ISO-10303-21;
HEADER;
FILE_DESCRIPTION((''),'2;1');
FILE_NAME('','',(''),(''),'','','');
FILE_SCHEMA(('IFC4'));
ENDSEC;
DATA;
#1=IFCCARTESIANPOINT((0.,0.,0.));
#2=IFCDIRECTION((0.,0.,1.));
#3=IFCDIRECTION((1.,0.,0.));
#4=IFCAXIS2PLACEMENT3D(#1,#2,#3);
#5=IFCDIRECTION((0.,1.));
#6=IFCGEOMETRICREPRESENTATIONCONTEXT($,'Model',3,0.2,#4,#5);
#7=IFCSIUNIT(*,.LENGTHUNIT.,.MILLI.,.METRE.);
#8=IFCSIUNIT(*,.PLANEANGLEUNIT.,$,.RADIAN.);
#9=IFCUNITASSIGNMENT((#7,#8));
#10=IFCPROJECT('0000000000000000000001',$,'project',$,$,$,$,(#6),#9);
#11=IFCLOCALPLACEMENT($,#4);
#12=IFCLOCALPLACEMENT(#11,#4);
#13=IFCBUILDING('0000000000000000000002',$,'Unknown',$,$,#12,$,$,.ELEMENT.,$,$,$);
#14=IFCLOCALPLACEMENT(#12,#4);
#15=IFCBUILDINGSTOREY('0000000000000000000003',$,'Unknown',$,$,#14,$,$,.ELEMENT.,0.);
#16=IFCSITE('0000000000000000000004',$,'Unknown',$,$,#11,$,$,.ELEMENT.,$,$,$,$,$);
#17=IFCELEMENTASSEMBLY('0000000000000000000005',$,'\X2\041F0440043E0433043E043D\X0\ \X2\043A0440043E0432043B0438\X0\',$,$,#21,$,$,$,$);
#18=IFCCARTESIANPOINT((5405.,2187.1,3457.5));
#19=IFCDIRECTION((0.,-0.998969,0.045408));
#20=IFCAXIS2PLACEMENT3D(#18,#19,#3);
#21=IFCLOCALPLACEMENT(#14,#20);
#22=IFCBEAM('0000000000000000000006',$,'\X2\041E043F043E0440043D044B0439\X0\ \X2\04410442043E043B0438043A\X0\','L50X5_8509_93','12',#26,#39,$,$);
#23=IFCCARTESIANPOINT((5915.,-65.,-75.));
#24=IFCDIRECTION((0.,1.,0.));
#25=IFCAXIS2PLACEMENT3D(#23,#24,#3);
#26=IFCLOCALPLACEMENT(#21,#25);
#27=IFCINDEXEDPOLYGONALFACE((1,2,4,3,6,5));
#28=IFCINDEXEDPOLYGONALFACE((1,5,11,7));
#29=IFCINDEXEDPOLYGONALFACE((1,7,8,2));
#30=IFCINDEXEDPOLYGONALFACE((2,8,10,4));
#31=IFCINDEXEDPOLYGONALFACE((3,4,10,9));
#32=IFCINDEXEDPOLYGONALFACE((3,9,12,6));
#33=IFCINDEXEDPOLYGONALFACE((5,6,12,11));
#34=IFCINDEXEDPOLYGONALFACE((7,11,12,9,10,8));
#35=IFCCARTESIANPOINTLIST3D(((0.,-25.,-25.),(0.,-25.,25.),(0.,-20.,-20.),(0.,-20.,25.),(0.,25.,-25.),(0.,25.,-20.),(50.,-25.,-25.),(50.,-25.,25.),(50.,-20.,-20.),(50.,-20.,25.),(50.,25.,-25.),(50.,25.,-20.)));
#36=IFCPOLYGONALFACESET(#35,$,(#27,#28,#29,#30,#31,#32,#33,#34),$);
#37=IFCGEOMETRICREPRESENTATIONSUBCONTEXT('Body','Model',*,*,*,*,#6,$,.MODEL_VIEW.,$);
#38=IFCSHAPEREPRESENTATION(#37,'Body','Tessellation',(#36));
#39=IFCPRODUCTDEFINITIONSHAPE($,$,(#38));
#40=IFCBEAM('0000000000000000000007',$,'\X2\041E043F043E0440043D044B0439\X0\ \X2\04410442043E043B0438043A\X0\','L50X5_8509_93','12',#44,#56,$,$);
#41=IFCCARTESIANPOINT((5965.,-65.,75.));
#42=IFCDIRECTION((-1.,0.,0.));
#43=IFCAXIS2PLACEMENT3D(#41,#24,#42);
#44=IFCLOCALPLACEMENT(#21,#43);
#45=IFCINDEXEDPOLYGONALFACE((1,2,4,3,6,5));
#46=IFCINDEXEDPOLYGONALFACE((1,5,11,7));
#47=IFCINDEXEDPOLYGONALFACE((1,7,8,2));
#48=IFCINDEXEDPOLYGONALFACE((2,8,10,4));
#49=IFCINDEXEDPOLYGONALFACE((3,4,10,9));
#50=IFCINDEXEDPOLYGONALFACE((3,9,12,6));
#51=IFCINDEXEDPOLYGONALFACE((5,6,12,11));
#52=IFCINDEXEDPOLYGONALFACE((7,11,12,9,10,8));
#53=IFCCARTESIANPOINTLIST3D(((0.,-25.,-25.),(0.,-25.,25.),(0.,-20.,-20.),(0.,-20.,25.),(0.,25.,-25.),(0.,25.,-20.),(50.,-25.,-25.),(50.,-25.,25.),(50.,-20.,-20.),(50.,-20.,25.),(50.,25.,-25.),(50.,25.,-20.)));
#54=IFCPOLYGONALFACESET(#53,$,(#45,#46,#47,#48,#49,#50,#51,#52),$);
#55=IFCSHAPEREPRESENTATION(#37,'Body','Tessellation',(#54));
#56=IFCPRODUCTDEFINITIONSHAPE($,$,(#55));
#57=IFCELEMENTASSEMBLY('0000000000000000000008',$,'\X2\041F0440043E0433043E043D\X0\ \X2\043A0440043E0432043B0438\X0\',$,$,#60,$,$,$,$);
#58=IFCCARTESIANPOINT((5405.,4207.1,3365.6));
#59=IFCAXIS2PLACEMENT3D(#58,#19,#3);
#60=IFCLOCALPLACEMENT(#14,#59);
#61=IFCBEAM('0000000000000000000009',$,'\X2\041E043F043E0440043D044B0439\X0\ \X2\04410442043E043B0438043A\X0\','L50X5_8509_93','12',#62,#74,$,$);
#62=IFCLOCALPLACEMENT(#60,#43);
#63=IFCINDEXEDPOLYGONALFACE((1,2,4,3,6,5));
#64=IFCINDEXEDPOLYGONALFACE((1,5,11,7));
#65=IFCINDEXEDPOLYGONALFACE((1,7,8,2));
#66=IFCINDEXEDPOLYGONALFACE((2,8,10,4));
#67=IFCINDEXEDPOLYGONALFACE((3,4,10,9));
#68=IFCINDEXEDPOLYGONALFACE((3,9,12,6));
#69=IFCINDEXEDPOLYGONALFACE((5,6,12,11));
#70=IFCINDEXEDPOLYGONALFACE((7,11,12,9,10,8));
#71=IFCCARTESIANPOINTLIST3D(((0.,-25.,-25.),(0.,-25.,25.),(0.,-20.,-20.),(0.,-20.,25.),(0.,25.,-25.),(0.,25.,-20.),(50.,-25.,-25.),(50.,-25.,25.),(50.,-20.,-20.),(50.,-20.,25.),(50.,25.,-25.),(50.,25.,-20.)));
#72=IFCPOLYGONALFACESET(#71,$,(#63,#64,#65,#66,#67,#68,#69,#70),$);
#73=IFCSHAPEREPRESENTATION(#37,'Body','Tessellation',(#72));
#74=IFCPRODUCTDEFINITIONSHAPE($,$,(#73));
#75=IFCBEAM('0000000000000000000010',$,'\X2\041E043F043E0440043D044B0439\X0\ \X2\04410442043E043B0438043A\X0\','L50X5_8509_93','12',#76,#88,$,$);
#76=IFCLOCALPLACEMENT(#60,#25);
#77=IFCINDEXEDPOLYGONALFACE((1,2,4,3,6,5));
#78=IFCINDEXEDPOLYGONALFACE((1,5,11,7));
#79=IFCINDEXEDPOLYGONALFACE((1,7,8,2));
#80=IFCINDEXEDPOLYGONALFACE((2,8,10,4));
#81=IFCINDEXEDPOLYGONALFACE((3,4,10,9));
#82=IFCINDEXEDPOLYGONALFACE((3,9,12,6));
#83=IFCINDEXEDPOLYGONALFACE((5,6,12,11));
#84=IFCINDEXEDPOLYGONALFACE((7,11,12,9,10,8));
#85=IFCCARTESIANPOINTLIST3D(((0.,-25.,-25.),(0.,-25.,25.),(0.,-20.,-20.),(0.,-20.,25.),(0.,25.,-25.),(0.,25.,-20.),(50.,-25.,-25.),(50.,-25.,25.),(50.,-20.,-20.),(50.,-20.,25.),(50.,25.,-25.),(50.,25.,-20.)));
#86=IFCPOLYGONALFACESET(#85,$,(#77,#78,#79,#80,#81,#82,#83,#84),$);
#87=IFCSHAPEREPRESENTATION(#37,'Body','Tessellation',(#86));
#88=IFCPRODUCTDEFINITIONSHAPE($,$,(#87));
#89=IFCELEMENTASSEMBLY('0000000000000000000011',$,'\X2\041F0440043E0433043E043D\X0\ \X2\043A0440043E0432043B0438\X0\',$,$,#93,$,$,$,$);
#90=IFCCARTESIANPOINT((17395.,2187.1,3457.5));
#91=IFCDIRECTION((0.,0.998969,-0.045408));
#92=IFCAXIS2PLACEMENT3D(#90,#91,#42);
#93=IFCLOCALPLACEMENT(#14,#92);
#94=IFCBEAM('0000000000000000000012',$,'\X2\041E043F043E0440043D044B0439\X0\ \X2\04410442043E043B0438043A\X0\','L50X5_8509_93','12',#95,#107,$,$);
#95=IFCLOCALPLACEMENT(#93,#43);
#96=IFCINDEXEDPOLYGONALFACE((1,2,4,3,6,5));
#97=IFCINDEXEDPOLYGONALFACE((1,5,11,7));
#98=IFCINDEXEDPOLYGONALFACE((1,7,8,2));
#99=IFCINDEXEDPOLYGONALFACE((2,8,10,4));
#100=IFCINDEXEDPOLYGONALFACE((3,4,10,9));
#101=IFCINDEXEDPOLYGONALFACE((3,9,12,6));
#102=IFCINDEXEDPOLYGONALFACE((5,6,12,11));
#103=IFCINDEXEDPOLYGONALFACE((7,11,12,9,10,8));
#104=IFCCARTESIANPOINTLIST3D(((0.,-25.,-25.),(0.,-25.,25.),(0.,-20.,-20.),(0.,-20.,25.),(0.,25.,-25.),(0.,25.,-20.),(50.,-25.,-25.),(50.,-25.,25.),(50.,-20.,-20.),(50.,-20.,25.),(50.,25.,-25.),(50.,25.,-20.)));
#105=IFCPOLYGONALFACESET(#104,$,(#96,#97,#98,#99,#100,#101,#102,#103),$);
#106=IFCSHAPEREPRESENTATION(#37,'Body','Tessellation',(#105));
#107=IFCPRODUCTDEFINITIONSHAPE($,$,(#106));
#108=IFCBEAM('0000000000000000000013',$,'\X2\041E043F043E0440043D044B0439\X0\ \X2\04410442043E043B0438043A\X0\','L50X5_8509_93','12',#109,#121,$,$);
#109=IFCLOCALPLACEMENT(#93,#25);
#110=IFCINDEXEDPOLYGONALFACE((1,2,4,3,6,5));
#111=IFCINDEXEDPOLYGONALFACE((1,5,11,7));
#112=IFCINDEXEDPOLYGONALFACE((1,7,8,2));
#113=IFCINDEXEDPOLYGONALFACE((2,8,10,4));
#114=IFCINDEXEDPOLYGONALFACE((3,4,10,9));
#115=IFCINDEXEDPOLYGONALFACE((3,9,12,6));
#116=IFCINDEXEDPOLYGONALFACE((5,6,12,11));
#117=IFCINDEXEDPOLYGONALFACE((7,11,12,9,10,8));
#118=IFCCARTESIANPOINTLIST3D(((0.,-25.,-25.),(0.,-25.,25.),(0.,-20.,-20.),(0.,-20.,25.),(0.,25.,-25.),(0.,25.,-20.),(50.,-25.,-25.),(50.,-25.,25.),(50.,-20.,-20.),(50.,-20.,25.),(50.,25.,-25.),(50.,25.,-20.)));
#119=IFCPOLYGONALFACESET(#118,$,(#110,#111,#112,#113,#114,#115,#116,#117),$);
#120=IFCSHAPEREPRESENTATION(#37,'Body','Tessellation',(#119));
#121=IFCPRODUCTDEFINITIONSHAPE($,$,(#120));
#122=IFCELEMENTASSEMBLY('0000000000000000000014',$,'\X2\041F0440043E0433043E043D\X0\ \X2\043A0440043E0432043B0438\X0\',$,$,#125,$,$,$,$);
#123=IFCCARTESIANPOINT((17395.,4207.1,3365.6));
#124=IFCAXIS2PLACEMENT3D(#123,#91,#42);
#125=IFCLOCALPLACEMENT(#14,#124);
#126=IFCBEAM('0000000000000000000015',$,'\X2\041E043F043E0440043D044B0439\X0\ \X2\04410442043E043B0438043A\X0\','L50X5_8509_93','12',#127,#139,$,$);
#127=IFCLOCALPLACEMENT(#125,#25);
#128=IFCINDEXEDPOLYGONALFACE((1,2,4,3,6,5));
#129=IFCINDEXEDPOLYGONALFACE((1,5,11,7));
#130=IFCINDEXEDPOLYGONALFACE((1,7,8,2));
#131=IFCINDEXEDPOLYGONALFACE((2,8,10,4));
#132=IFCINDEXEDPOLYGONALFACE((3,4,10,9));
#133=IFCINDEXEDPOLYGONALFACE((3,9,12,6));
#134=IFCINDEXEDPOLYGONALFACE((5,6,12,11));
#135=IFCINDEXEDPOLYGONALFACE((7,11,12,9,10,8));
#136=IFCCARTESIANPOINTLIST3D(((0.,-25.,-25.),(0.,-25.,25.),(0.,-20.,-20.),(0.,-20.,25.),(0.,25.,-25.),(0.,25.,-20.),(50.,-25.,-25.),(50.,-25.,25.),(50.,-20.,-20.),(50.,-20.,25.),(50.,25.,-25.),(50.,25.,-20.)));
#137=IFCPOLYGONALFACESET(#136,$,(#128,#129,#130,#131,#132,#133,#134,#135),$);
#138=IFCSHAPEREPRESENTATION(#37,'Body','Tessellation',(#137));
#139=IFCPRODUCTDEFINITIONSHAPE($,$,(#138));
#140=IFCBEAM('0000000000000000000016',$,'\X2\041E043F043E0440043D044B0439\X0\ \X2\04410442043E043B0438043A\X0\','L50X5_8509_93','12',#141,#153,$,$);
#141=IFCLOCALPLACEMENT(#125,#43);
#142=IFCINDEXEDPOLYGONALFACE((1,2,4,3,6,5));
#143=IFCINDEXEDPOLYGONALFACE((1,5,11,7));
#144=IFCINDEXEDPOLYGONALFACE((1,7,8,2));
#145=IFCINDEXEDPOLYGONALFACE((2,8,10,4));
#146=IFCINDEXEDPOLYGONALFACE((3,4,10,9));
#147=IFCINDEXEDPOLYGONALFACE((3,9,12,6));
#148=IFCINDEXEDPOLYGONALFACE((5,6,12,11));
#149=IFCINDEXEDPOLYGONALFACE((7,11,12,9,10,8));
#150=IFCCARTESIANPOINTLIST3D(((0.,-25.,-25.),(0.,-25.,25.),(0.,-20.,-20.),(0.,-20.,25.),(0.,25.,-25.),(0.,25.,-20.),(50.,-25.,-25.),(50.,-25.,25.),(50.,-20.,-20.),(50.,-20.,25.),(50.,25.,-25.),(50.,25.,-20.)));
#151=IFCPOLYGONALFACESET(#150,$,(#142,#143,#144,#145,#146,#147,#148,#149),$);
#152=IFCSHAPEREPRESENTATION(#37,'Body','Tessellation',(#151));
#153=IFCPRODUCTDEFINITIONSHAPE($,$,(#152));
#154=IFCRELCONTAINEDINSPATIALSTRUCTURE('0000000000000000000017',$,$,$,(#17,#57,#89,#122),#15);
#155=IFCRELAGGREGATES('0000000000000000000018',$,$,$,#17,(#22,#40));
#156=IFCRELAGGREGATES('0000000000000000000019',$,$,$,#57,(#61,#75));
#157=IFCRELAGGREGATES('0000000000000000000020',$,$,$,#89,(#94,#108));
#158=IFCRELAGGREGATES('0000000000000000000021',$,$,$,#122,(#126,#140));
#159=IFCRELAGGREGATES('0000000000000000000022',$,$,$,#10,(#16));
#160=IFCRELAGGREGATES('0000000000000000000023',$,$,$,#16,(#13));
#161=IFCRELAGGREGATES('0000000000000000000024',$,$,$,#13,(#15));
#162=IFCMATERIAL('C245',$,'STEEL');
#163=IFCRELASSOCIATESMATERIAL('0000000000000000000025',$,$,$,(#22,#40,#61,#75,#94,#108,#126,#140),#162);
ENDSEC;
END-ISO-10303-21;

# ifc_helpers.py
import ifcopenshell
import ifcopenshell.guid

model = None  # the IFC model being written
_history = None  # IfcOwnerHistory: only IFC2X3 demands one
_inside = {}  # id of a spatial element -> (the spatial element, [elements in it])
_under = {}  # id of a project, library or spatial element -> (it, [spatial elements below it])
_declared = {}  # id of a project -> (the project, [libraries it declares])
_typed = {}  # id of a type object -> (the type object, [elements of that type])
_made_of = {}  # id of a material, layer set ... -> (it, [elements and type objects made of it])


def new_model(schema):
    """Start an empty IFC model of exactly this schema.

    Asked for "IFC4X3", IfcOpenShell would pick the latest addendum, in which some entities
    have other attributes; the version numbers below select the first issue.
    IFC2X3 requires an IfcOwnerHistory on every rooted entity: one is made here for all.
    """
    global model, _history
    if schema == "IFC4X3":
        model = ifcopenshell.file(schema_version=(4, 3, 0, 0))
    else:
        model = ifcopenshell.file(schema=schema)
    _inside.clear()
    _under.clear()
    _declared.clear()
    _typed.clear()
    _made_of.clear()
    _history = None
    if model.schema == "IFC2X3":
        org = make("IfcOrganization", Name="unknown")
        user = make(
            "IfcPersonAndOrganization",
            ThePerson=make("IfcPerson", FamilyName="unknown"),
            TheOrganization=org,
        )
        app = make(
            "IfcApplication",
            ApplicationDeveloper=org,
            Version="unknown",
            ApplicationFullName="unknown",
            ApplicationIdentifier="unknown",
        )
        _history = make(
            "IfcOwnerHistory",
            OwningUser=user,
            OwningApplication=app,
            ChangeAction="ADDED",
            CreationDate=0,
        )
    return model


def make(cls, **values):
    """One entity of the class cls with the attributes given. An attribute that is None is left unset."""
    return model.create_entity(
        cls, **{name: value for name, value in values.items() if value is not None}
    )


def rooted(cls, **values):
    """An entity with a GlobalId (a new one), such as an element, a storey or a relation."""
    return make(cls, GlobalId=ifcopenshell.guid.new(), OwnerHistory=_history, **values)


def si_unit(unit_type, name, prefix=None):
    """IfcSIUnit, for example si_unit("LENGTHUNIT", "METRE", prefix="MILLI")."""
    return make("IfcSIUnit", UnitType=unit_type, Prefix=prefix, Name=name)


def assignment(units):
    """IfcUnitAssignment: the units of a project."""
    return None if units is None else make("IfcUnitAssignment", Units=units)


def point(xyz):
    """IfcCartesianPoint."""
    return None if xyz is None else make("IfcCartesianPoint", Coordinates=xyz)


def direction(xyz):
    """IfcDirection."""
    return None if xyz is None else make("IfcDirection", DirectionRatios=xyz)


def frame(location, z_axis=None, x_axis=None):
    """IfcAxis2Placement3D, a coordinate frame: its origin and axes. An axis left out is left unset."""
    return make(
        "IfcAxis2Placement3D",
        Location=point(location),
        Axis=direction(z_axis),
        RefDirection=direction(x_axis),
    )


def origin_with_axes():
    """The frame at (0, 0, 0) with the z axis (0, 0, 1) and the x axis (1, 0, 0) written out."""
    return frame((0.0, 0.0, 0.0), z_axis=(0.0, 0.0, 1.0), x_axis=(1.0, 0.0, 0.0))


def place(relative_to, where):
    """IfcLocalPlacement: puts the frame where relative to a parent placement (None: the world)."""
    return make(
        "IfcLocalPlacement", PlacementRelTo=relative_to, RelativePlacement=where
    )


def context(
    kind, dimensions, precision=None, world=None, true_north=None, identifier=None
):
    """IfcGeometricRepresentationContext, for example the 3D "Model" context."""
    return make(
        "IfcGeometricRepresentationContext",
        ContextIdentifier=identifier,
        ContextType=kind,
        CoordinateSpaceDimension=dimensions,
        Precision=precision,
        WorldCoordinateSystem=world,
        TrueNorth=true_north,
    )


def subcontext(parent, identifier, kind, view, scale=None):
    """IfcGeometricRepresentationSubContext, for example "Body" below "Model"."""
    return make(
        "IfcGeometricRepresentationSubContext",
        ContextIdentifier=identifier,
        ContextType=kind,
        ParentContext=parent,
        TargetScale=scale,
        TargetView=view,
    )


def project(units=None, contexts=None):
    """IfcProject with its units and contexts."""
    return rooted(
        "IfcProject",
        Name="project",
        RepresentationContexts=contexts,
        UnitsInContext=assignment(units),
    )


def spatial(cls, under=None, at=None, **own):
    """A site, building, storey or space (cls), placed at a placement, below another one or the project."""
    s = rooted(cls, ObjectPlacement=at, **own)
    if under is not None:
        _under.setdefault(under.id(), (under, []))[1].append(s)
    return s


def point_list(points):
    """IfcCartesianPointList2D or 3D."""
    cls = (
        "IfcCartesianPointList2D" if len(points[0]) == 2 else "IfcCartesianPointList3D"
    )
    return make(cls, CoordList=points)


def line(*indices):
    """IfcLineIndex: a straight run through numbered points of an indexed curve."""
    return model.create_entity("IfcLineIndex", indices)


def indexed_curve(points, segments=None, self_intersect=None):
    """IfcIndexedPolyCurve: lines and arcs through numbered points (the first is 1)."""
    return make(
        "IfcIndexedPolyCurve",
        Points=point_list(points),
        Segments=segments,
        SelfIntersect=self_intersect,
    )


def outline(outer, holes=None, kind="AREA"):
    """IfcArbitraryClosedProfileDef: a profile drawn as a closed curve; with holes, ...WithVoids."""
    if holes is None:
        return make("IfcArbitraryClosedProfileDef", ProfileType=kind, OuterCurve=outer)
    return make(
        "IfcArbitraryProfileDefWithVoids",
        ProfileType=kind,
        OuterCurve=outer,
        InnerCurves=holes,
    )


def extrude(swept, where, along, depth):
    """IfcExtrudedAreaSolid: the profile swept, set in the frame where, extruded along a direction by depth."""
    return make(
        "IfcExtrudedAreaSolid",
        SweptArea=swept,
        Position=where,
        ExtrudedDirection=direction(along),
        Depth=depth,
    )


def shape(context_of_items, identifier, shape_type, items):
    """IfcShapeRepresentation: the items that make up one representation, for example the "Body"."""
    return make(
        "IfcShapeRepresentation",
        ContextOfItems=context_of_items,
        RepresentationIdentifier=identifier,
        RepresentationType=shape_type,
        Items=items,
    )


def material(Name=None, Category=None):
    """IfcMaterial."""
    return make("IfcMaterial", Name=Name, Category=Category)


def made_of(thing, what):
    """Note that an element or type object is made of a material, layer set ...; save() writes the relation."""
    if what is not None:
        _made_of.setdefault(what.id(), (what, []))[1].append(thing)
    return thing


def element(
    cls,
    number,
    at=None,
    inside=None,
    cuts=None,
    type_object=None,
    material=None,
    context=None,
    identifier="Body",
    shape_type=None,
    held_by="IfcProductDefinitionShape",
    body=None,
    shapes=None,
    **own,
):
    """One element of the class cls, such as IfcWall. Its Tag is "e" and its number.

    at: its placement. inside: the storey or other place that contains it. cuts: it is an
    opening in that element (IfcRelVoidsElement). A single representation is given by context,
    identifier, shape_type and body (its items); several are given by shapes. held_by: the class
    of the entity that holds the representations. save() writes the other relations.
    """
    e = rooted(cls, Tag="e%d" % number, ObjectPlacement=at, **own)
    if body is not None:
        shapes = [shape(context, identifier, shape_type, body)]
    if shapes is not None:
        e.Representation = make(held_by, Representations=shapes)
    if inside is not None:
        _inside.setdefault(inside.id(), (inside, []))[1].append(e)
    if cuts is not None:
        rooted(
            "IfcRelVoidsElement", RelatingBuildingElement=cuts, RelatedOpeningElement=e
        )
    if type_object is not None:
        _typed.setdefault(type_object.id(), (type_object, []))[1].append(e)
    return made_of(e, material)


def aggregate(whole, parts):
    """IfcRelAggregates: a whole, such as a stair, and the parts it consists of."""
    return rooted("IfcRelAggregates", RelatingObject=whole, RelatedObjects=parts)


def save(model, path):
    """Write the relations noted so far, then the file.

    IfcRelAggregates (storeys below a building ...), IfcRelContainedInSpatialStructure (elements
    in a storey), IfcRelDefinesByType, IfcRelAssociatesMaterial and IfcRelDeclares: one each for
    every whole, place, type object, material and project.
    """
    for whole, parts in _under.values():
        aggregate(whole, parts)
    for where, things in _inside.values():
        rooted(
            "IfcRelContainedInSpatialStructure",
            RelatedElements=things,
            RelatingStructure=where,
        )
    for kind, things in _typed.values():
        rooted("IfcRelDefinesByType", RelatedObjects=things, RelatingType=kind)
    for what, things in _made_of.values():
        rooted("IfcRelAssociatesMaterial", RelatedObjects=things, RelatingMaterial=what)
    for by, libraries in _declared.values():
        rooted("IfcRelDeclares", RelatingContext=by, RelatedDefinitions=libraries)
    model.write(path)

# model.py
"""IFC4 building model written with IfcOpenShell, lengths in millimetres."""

from ifc_helpers import new_model, si_unit, direction, frame, origin_with_axes, place, context, subcontext, project, spatial, line, indexed_curve, outline, extrude, material, element, aggregate, save


model = new_model("IFC4")

# Units and contexts
model_context = context("Model", 3, precision=0.2, world=origin_with_axes(), true_north=direction((0.0, 1.0)))
body_context = subcontext(model_context, "Body", "Model", "MODEL_VIEW")
ifc_project = project(units=[si_unit("LENGTHUNIT", "METRE", prefix="MILLI"), si_unit("PLANEANGLEUNIT", "RADIAN")], contexts=[model_context])

# Site, building, storey
site_placement = place(None, origin_with_axes())
site = spatial("IfcSite", under=ifc_project, at=site_placement, Name="Unknown", CompositionType="ELEMENT")
building_placement = place(site_placement, origin_with_axes())
building = spatial("IfcBuilding", under=site, at=building_placement, Name="Unknown", CompositionType="ELEMENT")
storey_placement = place(building_placement, origin_with_axes())
storey = spatial("IfcBuildingStorey", under=building, at=storey_placement, Name="Unknown", CompositionType="ELEMENT", Elevation=0.0)

# Element assembly, beams
assembly_1_placement = place(storey_placement, frame((5405.0, 2187.1, 3457.5), z_axis=(0.0, -0.998969, 0.045408), x_axis=(1.0, 0.0, 0.0)))
assembly_1 = element("IfcElementAssembly", 1, at=assembly_1_placement, inside=storey, Name="Прогон кровли")
ifc_material_1 = material(Name="C245", Category="STEEL")
beam_1_placement = place(assembly_1_placement, frame((5915.0, -65.0, -75.0), z_axis=(0.0, 1.0, 0.0), x_axis=(1.0, 0.0, 0.0)))
beam_1 = element("IfcBeam", 2, at=beam_1_placement, material=ifc_material_1, Name="Опорный столик", Description="L50X5_8509_93", ObjectType="12", context=body_context, shape_type="SolidModel", body=[
    extrude(outline(indexed_curve([(-25.0, -25.0), (25.0, -25.0), (25.0, -20.0), (-20.0, -20.0), (-20.0, 25.0), (-25.0, 25.0)], segments=[line(1, 2, 3, 4, 5, 6, 1)])), frame((0.0, 0.0, 0.0), z_axis=(-1.0, 0.0, 0.0), x_axis=(0.0, 0.0, 1.0)), (0.0, 0.0, -1.0), 50.0),
])
beam_2_placement = place(assembly_1_placement, frame((5965.0, -65.0, 75.0), z_axis=(0.0, 1.0, 0.0), x_axis=(-1.0, 0.0, 0.0)))
beam_2 = element("IfcBeam", 3, at=beam_2_placement, material=ifc_material_1, Name="Опорный столик", Description="L50X5_8509_93", ObjectType="12", context=body_context, shape_type="SolidModel", body=[
    extrude(outline(indexed_curve([(-25.0, -25.0), (25.0, -25.0), (25.0, -20.0), (-20.0, -20.0), (-20.0, 25.0), (-25.0, 25.0)], segments=[line(1, 2, 3, 4, 5, 6, 1)])), frame((0.0, 0.0, 0.0), z_axis=(-1.0, 0.0, 0.0), x_axis=(0.0, 0.0, 1.0)), (0.0, 0.0, -1.0), 50.0),
])
aggregate(assembly_1, [beam_1, beam_2])

# Element assembly, beams
assembly_2_placement = place(storey_placement, frame((5405.0, 4207.1, 3365.6), z_axis=(0.0, -0.998969, 0.045408), x_axis=(1.0, 0.0, 0.0)))
assembly_2 = element("IfcElementAssembly", 4, at=assembly_2_placement, inside=storey, Name="Прогон кровли")
beam_3_placement = place(assembly_2_placement, frame((5965.0, -65.0, 75.0), z_axis=(0.0, 1.0, 0.0), x_axis=(-1.0, 0.0, 0.0)))
beam_3 = element("IfcBeam", 5, at=beam_3_placement, material=ifc_material_1, Name="Опорный столик", Description="L50X5_8509_93", ObjectType="12", context=body_context, shape_type="SolidModel", body=[
    extrude(outline(indexed_curve([(-25.0, -25.0), (25.0, -25.0), (25.0, -20.0), (-20.0, -20.0), (-20.0, 25.0), (-25.0, 25.0)], segments=[line(1, 2, 3, 4, 5, 6, 1)])), frame((0.0, 0.0, 0.0), z_axis=(-1.0, 0.0, 0.0), x_axis=(0.0, 0.0, 1.0)), (0.0, 0.0, -1.0), 50.0),
])
beam_4_placement = place(assembly_2_placement, frame((5915.0, -65.0, -75.0), z_axis=(0.0, 1.0, 0.0), x_axis=(1.0, 0.0, 0.0)))
beam_4 = element("IfcBeam", 6, at=beam_4_placement, material=ifc_material_1, Name="Опорный столик", Description="L50X5_8509_93", ObjectType="12", context=body_context, shape_type="SolidModel", body=[
    extrude(outline(indexed_curve([(-25.0, -25.0), (25.0, -25.0), (25.0, -20.0), (-20.0, -20.0), (-20.0, 25.0), (-25.0, 25.0)], segments=[line(1, 2, 3, 4, 5, 6, 1)])), frame((0.0, 0.0, 0.0), z_axis=(-1.0, 0.0, 0.0), x_axis=(0.0, 0.0, 1.0)), (0.0, 0.0, -1.0), 50.0),
])
aggregate(assembly_2, [beam_3, beam_4])

# Element assembly, beams
assembly_3_placement = place(storey_placement, frame((17395.0, 2187.1, 3457.5), z_axis=(0.0, 0.998969, -0.045408), x_axis=(-1.0, 0.0, 0.0)))
assembly_3 = element("IfcElementAssembly", 7, at=assembly_3_placement, inside=storey, Name="Прогон кровли")
beam_5_placement = place(assembly_3_placement, frame((5965.0, -65.0, 75.0), z_axis=(0.0, 1.0, 0.0), x_axis=(-1.0, 0.0, 0.0)))
beam_5 = element("IfcBeam", 8, at=beam_5_placement, material=ifc_material_1, Name="Опорный столик", Description="L50X5_8509_93", ObjectType="12", context=body_context, shape_type="SolidModel", body=[
    extrude(outline(indexed_curve([(-25.0, -25.0), (25.0, -25.0), (25.0, -20.0), (-20.0, -20.0), (-20.0, 25.0), (-25.0, 25.0)], segments=[line(1, 2, 3, 4, 5, 6, 1)])), frame((0.0, 0.0, 0.0), z_axis=(-1.0, 0.0, 0.0), x_axis=(0.0, 0.0, 1.0)), (0.0, 0.0, -1.0), 50.0),
])
beam_6_placement = place(assembly_3_placement, frame((5915.0, -65.0, -75.0), z_axis=(0.0, 1.0, 0.0), x_axis=(1.0, 0.0, 0.0)))
beam_6 = element("IfcBeam", 9, at=beam_6_placement, material=ifc_material_1, Name="Опорный столик", Description="L50X5_8509_93", ObjectType="12", context=body_context, shape_type="SolidModel", body=[
    extrude(outline(indexed_curve([(-25.0, -25.0), (25.0, -25.0), (25.0, -20.0), (-20.0, -20.0), (-20.0, 25.0), (-25.0, 25.0)], segments=[line(1, 2, 3, 4, 5, 6, 1)])), frame((0.0, 0.0, 0.0), z_axis=(-1.0, 0.0, 0.0), x_axis=(0.0, 0.0, 1.0)), (0.0, 0.0, -1.0), 50.0),
])

# Element assembly, beams
assembly_4_placement = place(storey_placement, frame((17395.0, 4207.1, 3365.6), z_axis=(0.0, 0.998969, -0.045408), x_axis=(-1.0, 0.0, 0.0)))
assembly_4 = element("IfcElementAssembly", 10, at=assembly_4_placement, inside=storey, Name="Прогон кровли")
beam_7_placement = place(assembly_4_placement, frame((5915.0, -65.0, -75.0), z_axis=(0.0, 1.0, 0.0), x_axis=(1.0, 0.0, 0.0)))
beam_7 = element("IfcBeam", 11, at=beam_7_placement, material=ifc_material_1, Name="Опорный столик", Description="L50X5_8509_93", ObjectType="12", context=body_context, shape_type="SolidModel", body=[
    extrude(outline(indexed_curve([(-25.0, -25.0), (25.0, -25.0), (25.0, -20.0), (-20.0, -20.0), (-20.0, 25.0), (-25.0, 25.0)], segments=[line(1, 2, 3, 4, 5, 6, 1)])), frame((0.0, 0.0, 0.0), z_axis=(-1.0, 0.0, 0.0), x_axis=(0.0, 0.0, 1.0)), (0.0, 0.0, -1.0), 50.0),
])
beam_8_placement = place(assembly_4_placement, frame((5965.0, -65.0, 75.0), z_axis=(0.0, 1.0, 0.0), x_axis=(-1.0, 0.0, 0.0)))
beam_8 = element("IfcBeam", 12, at=beam_8_placement, material=ifc_material_1, Name="Опорный столик", Description="L50X5_8509_93", ObjectType="12", context=body_context, shape_type="SolidModel", body=[
    extrude(outline(indexed_curve([(-25.0, -25.0), (25.0, -25.0), (25.0, -20.0), (-20.0, -20.0), (-20.0, 25.0), (-25.0, 25.0)], segments=[line(1, 2, 3, 4, 5, 6, 1)])), frame((0.0, 0.0, 0.0), z_axis=(-1.0, 0.0, 0.0), x_axis=(0.0, 0.0, 1.0)), (0.0, 0.0, -1.0), 50.0),
])

aggregate(assembly_3, [beam_5, beam_6])
aggregate(assembly_4, [beam_7, beam_8])

save(model, "model.ifc")
